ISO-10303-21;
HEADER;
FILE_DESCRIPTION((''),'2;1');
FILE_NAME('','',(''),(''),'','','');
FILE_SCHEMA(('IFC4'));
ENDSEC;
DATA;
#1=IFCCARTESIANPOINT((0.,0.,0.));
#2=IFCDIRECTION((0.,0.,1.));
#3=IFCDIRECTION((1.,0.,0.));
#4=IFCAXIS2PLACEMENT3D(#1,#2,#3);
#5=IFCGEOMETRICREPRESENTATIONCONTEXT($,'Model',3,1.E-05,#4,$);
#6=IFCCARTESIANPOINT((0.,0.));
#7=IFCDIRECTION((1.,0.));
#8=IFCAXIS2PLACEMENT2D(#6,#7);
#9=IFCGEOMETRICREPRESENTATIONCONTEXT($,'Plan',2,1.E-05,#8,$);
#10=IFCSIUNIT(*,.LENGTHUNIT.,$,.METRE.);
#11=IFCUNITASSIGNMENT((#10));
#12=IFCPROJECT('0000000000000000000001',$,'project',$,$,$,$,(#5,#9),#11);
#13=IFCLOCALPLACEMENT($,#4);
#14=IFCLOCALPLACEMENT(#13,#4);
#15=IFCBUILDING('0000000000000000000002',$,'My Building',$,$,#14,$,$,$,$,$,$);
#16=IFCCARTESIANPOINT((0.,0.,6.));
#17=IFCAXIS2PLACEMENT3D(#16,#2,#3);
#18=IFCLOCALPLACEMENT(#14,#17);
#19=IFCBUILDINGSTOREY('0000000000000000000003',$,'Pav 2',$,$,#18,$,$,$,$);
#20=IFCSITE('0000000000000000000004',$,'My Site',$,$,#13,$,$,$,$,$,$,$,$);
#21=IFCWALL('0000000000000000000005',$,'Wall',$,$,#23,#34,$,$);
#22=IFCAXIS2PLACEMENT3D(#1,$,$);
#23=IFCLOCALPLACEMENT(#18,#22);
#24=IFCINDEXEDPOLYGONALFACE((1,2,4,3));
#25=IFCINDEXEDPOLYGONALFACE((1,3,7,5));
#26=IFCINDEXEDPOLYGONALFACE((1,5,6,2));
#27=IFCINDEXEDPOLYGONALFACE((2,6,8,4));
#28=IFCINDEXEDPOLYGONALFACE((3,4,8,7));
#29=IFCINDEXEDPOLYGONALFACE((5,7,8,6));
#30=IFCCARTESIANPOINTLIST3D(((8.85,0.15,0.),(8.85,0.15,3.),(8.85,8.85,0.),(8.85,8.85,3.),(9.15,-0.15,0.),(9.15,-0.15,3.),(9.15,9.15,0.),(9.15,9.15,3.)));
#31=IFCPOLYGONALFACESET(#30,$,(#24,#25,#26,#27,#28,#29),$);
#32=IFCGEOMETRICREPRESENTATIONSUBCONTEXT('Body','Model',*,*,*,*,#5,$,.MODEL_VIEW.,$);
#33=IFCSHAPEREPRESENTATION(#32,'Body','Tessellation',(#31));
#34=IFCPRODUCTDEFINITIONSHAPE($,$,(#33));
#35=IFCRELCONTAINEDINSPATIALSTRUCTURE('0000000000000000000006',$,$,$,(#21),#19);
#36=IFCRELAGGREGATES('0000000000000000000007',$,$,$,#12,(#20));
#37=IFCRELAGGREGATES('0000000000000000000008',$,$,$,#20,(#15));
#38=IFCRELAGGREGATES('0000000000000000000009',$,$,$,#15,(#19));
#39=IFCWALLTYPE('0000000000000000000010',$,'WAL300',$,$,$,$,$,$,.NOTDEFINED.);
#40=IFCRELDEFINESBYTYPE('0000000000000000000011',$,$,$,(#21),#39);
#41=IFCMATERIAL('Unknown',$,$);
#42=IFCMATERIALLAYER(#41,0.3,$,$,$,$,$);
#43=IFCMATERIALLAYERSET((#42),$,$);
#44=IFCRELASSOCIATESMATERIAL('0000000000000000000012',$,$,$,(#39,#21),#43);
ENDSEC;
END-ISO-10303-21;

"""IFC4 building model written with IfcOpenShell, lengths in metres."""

from ifc_helpers import new_model, si_unit, frame, origin_with_axes, origin_2d_with_axis, place, context, subcontext, project, spatial, line, indexed_curve, outline, extrude, material, layer, layer_set, layer_usage, type_object, element, save


model = new_model("IFC4")

# Units and contexts
model_context = context("Model", 3, precision=1e-05, world=origin_with_axes())
plan_context = context("Plan", 2, precision=1e-05, world=origin_2d_with_axis())
body_context = subcontext(model_context, "Body", "Model", "MODEL_VIEW")
ifc_project = project(units=[si_unit("LENGTHUNIT", "METRE")], contexts=[model_context, plan_context])

# Site, building, storey
site_placement = place(None, origin_with_axes())
site = spatial("IfcSite", under=ifc_project, at=site_placement, Name="My Site")
building_placement = place(site_placement, origin_with_axes())
building = spatial("IfcBuilding", under=site, at=building_placement, Name="My Building")
storey_placement = place(building_placement, frame((0.0, 0.0, 6.0), z_axis=(0.0, 0.0, 1.0), x_axis=(1.0, 0.0, 0.0)))
storey = spatial("IfcBuildingStorey", under=building, at=storey_placement, Name="Pav 2")

# Shared definitions
ifc_material = material(Name="Unknown")

# Wall
ifc_layer_1 = layer(ifc_material, 0.3)
ifc_layer_set_1 = layer_set([ifc_layer_1])
wall_type = type_object("IfcWallType", Name="WAL300", PredefinedType="NOTDEFINED", material=ifc_layer_set_1)
ifc_layer_usage_1 = layer_usage(ifc_layer_set_1, "AXIS2", "POSITIVE", -0.15)
wall_1_placement = place(storey_placement, frame((9.0, 9.0, 0.0), z_axis=(0.0, 0.0, 1.0), x_axis=(0.0, -1.0, 0.0)))
element("IfcWall", 1, at=wall_1_placement, inside=storey, type_object=wall_type, material=ifc_layer_usage_1, Name="Wall", context=body_context, shape_type="SweptSolid", body=[
    extrude(outline(indexed_curve([(0.15, -0.15), (-0.15, 0.15), (9.15, 0.15), (8.85, -0.15)], segments=[line(1, 2, 3, 4, 1)])), origin_with_axes(), (0.0, 0.0, 1.0), 3.0),
])

save(model, "model.ifc")
